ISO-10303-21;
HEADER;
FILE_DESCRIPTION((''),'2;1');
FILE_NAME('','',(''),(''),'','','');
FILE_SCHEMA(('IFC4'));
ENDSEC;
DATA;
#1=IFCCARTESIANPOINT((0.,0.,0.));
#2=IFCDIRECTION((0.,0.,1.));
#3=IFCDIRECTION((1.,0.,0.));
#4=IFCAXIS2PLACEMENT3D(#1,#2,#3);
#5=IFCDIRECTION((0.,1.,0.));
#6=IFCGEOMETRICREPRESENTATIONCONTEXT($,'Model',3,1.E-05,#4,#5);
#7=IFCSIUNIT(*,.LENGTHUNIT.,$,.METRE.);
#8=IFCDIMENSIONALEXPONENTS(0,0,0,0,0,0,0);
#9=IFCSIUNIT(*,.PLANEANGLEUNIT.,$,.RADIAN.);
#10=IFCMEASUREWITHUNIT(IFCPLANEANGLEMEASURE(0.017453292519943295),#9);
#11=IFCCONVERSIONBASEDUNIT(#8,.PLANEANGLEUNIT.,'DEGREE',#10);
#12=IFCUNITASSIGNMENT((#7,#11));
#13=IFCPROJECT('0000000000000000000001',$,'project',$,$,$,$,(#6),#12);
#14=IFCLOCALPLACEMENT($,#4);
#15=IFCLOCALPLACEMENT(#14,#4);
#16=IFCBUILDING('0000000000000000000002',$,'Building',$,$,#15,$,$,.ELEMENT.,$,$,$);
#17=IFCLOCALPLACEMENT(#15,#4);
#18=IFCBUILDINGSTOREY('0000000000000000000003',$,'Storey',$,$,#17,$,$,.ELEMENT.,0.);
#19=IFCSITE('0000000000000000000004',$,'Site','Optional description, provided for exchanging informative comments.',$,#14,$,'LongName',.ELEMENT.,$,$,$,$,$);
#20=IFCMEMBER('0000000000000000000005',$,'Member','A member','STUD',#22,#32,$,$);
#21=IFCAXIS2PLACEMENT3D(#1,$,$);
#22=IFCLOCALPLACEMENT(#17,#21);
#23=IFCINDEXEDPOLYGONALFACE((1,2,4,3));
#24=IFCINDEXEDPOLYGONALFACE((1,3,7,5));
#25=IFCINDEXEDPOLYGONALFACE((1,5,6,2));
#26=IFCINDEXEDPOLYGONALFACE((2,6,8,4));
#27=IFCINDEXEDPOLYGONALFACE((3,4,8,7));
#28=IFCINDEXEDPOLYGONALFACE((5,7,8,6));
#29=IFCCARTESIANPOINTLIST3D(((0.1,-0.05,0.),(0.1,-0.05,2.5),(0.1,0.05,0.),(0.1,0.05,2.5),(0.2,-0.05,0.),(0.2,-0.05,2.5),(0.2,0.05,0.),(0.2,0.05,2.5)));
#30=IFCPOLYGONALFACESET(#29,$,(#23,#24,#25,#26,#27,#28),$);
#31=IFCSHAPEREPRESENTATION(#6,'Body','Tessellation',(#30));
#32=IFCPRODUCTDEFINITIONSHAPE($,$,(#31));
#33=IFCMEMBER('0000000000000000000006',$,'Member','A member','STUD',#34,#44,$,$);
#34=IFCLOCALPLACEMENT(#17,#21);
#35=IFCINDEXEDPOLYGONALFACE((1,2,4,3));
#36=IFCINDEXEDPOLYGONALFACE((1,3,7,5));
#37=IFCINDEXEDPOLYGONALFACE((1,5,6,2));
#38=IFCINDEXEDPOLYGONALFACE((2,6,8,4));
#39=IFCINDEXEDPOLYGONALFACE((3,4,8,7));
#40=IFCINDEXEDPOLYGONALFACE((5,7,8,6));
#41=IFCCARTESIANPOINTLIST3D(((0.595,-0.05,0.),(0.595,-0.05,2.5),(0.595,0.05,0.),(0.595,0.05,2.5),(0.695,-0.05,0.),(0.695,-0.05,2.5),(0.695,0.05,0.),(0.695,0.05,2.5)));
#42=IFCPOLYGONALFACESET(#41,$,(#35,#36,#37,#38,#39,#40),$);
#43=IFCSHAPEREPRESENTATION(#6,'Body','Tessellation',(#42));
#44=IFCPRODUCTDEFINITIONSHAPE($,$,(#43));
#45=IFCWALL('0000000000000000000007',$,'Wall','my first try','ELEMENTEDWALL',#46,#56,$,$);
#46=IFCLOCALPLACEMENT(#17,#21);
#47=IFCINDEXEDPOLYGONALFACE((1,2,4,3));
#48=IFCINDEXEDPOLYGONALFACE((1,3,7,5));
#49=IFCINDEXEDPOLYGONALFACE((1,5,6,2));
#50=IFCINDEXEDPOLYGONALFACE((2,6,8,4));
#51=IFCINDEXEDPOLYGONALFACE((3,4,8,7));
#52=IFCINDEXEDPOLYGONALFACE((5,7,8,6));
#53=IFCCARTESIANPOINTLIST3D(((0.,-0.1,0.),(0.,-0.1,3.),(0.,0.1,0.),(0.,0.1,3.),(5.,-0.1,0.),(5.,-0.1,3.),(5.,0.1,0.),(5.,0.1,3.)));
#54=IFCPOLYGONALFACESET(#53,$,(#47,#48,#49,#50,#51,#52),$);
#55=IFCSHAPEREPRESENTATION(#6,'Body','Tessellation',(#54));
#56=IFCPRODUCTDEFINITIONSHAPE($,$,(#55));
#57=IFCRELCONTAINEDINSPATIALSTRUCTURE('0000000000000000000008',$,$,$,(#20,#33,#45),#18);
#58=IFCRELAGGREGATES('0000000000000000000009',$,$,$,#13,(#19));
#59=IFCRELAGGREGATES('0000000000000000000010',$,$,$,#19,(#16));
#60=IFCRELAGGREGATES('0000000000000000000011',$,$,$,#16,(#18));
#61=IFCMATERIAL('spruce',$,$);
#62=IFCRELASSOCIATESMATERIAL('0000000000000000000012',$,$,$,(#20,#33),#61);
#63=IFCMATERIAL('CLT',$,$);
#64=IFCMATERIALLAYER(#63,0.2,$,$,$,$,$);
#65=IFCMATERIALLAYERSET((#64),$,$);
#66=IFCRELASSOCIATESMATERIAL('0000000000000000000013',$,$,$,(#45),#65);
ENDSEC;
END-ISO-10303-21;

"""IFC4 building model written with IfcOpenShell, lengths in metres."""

from ifc_helpers import new_model, entity, si_unit, converted_unit, direction, frame, origin_with_axes, place, context, project, spatial, polyline, outline, extrude, material, layer, layer_set, layer_usage, element, save


model = new_model("IFC4")

# Units and contexts
model_context = context("Model", 3, precision=1e-05, world=origin_with_axes(), true_north=direction((0.0, 1.0, 0.0)))
ifc_project = project(units=[si_unit("LENGTHUNIT", "METRE"), converted_unit("PLANEANGLEUNIT", "DEGREE", entity("IfcPlaneAngleMeasure", 0.017453292519943295), si_unit("PLANEANGLEUNIT", "RADIAN"), dimensions=[0, 0, 0, 0, 0, 0, 0])], contexts=[model_context])

# Site, building, storey
site_placement = place(None, origin_with_axes())
site = spatial("IfcSite", under=ifc_project, at=site_placement, Name="Site", Description="Optional description, provided for exchanging informative comments.", LongName="LongName", CompositionType="ELEMENT")
building_placement = place(site_placement, origin_with_axes())
building = spatial("IfcBuilding", under=site, at=building_placement, Name="Building", CompositionType="ELEMENT")
storey_placement = place(building_placement, origin_with_axes())
storey = spatial("IfcBuildingStorey", under=building, at=storey_placement, Name="Storey", CompositionType="ELEMENT", Elevation=0.0)

# Members
ifc_material_1 = material(Name="spruce")
placement = place(storey_placement, origin_with_axes())
element("IfcMember", 1, at=placement, inside=storey, material=ifc_material_1, Name="Member", Description="A member", ObjectType="STUD", context=model_context, shape_type="SweptSolid", body=[
    extrude(outline(polyline([(0.0, -0.05), (0.1, -0.05), (0.1, 0.05), (0.0, 0.05), (0.0, -0.05)])), frame((0.1, 0.0, 0.0), z_axis=(0.0, 0.0, 1.0), x_axis=(1.0, 0.0, 0.0)), (0.0, 0.0, 1.0), 2.5),
])
element("IfcMember", 2, at=placement, inside=storey, material=ifc_material_1, Name="Member", Description="A member", ObjectType="STUD", context=model_context, shape_type="SweptSolid", body=[
    extrude(outline(polyline([(0.0, -0.05), (0.1, -0.05), (0.1, 0.05), (0.0, 0.05), (0.0, -0.05)])), frame((0.595, 0.0, 0.0), z_axis=(0.0, 0.0, 1.0), x_axis=(1.0, 0.0, 0.0)), (0.0, 0.0, 1.0), 2.5),
])

# Wall
ifc_material_2 = material(Name="CLT")
ifc_layer = layer(ifc_material_2, 0.2)
ifc_layer_set = layer_set([ifc_layer])
ifc_layer_usage = layer_usage(ifc_layer_set, "AXIS2", "POSITIVE", -0.1)
wall_placement = place(storey_placement, origin_with_axes())
element("IfcWall", 3, at=wall_placement, inside=storey, material=ifc_layer_usage, Name="Wall", Description="my first try", ObjectType="ELEMENTEDWALL", context=model_context, shape_type="SweptSolid", body=[
    extrude(outline(polyline([(0.0, -0.1), (5.0, -0.1), (5.0, 0.1), (0.0, 0.1), (0.0, -0.1)])), origin_with_axes(), (0.0, 0.0, 1.0), 3.0),
])

save(model, "model.ifc")
